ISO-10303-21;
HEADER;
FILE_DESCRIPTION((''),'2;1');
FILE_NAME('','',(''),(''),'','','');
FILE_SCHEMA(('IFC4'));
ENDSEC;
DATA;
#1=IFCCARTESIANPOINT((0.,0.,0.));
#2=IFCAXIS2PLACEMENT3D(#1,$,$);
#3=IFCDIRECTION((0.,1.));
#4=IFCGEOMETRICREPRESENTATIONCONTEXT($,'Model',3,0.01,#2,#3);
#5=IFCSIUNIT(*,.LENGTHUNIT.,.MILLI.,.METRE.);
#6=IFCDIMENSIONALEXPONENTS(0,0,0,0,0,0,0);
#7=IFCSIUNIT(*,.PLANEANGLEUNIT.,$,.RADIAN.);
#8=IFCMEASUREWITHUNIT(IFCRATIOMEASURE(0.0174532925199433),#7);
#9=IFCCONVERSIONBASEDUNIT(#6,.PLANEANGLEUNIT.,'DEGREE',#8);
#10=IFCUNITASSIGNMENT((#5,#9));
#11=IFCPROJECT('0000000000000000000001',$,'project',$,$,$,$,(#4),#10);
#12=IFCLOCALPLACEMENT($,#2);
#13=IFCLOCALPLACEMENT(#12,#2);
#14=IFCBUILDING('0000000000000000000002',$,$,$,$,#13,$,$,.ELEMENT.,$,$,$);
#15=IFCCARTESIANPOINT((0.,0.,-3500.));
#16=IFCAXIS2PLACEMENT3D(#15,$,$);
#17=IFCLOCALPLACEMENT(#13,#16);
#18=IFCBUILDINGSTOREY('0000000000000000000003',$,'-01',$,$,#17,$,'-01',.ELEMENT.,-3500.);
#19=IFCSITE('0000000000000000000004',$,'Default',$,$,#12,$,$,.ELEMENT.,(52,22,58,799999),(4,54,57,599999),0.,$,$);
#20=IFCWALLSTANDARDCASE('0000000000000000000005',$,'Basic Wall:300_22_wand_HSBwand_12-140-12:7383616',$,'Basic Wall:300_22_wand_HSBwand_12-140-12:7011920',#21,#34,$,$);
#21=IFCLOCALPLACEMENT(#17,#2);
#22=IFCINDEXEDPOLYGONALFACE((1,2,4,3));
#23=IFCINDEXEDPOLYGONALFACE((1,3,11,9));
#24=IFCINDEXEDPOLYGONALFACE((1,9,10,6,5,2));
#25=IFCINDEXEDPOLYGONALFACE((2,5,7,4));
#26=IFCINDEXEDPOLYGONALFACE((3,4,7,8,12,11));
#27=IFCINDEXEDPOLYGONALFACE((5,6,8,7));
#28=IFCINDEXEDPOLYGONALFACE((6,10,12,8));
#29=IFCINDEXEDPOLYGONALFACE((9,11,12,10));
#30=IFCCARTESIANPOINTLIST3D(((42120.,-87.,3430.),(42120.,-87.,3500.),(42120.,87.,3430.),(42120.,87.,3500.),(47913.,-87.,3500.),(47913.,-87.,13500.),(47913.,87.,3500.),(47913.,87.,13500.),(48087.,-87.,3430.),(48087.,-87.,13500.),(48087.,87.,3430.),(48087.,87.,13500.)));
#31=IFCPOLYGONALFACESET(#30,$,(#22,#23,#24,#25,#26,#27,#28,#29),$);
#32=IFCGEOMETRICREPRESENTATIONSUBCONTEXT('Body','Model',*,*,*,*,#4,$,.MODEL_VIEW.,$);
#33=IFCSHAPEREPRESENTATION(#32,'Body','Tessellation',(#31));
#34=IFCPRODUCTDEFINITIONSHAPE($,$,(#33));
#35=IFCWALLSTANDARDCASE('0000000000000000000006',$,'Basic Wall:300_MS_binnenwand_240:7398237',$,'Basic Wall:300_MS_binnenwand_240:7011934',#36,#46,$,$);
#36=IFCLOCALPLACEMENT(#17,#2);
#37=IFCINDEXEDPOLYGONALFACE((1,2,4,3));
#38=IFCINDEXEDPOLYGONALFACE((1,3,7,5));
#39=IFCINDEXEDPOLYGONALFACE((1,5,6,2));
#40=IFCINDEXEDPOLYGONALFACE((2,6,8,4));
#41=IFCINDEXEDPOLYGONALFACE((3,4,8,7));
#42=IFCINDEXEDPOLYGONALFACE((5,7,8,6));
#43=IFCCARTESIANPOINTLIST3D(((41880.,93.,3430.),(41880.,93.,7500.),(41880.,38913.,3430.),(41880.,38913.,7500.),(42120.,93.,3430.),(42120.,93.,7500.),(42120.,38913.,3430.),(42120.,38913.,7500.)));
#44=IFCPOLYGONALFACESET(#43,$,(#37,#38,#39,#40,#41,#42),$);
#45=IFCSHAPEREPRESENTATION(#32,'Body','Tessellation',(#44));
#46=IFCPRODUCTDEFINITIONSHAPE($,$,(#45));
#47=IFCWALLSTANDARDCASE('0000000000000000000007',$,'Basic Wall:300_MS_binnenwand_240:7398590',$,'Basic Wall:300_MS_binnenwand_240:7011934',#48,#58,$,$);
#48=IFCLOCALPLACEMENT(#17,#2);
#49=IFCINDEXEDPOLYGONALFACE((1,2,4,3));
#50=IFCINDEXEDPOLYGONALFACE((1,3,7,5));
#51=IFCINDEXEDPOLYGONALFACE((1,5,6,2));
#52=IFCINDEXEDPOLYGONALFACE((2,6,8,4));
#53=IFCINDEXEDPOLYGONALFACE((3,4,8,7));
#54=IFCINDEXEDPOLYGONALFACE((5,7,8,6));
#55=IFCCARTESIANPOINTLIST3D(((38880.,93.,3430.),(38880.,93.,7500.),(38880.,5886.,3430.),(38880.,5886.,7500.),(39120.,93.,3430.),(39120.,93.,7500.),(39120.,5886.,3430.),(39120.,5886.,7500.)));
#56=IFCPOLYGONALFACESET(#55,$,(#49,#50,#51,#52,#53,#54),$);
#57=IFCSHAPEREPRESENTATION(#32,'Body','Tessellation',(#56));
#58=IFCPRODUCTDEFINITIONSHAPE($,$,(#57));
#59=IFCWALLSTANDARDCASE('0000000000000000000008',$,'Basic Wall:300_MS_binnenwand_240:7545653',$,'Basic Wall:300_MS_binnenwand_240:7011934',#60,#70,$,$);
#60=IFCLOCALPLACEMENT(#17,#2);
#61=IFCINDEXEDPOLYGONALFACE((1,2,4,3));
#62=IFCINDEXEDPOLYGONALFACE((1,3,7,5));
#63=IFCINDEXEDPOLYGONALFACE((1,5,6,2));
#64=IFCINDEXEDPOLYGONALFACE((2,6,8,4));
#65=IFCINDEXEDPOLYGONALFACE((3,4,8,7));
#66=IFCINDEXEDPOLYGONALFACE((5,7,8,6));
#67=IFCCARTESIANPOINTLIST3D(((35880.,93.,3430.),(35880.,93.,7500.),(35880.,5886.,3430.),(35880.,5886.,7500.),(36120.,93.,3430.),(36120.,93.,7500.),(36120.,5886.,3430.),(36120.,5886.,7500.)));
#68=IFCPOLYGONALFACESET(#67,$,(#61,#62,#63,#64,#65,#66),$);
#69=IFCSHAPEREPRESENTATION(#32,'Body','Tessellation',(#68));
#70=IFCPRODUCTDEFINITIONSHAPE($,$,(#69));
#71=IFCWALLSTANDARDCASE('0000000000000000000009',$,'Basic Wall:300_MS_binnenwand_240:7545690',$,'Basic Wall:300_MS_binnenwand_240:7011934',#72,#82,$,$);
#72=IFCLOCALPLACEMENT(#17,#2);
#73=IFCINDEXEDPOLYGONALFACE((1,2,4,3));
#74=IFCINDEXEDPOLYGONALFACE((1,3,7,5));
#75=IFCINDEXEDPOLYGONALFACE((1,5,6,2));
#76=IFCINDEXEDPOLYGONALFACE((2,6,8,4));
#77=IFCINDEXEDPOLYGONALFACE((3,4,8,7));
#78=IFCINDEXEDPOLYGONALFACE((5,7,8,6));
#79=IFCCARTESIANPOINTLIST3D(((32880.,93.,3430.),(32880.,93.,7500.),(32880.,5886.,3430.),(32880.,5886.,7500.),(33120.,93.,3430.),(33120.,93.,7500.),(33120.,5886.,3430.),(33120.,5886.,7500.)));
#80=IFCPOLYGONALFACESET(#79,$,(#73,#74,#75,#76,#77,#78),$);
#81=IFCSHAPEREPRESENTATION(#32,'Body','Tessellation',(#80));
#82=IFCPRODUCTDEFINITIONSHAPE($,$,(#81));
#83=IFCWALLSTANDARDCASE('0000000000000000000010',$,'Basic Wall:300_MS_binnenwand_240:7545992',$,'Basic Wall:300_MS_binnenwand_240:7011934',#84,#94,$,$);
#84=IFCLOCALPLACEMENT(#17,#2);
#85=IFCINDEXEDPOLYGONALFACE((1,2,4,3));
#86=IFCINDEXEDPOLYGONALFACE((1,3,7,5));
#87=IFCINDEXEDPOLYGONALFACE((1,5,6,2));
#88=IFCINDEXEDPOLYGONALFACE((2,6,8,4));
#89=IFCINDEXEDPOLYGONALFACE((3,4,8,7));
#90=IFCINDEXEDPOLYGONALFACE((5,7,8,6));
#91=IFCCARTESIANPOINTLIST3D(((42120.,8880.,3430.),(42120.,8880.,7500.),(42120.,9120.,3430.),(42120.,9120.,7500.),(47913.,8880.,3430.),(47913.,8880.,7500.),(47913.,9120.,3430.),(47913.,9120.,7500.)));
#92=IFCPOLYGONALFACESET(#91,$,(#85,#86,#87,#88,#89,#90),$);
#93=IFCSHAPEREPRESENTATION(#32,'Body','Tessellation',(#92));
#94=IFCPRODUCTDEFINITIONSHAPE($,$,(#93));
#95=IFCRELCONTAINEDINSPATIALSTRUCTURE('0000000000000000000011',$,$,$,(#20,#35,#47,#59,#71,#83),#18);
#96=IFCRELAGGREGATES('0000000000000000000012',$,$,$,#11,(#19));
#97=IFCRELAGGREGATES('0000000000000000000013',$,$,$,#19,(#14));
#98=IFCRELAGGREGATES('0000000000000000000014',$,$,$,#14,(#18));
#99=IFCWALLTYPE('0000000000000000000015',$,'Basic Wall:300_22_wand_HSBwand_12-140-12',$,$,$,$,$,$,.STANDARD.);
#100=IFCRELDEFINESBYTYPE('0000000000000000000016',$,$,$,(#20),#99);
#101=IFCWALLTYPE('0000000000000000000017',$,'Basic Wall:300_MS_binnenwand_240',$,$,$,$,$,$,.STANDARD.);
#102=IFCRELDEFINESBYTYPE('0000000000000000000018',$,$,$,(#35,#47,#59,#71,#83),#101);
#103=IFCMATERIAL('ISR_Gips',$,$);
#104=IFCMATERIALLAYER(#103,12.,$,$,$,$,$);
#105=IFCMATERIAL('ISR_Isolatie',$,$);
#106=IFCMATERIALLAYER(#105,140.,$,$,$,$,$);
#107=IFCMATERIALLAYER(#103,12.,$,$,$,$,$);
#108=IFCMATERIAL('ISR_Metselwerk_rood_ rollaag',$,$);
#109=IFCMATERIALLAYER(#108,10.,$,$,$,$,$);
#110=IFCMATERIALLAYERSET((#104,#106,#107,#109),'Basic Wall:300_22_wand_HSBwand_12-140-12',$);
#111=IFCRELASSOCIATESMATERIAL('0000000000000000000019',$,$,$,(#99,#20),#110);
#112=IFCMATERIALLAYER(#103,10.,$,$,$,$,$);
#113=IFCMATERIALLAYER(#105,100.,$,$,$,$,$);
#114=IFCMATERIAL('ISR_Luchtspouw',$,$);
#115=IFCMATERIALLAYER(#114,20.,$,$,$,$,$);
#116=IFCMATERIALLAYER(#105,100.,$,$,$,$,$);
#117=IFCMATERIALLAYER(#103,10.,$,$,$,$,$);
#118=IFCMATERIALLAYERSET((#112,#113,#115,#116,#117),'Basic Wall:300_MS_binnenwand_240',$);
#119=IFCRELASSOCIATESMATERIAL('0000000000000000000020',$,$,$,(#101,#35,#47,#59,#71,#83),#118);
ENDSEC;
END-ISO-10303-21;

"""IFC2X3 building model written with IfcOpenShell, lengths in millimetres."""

from ifc_helpers import new_model, entity, si_unit, converted_unit, direction, frame, frame_2d, origin, place, context, subcontext, project, spatial, rectangle, extrude, material, layer, layer_set, layer_usage, type_object, element, save


model = new_model("IFC2X3")

# Units and contexts
model_context = context("Model", 3, precision=0.01, world=origin(), true_north=direction((0.0, 1.0)))
body_context = subcontext(model_context, "Body", "Model", "MODEL_VIEW")
ifc_project = project(units=[si_unit("LENGTHUNIT", "METRE", prefix="MILLI"), converted_unit("PLANEANGLEUNIT", "DEGREE", entity("IfcRatioMeasure", 0.0174532925199433), si_unit("PLANEANGLEUNIT", "RADIAN"), dimensions=[0, 0, 0, 0, 0, 0, 0])], contexts=[model_context])

# Site, building, storey
site_placement = place(None, origin())
site = spatial("IfcSite", under=ifc_project, at=site_placement, Name="Default", CompositionType="ELEMENT", RefLatitude=(52, 22, 58, 799999), RefLongitude=(4, 54, 57, 599999), RefElevation=0.0)
building_placement = place(site_placement, origin())
building = spatial("IfcBuilding", under=site, at=building_placement, CompositionType="ELEMENT")
storey_placement = place(building_placement, frame((0.0, 0.0, -3500.0)))
storey = spatial("IfcBuildingStorey", under=building, at=storey_placement, Name="-01", LongName="-01", CompositionType="ELEMENT", Elevation=-3500.0)

# Shared definitions
ifc_material_1 = material(Name="ISR_Gips")
ifc_layer_1 = layer(ifc_material_1, 12.0)
ifc_material_2 = material(Name="ISR_Isolatie")
ifc_layer_2 = layer(ifc_material_2, 140.0)
ifc_layer_3 = layer(ifc_material_1, 12.0)
ifc_material_3 = material(Name="ISR_Metselwerk_rood_ rollaag")
ifc_layer_4 = layer(ifc_material_3, 10.0)
ifc_layer_set_1 = layer_set([ifc_layer_1, ifc_layer_2, ifc_layer_3, ifc_layer_4], Name="Basic Wall:300_22_wand_HSBwand_12-140-12")
wall_type_1 = type_object("IfcWallType", Name="Basic Wall:300_22_wand_HSBwand_12-140-12", PredefinedType="STANDARD", material=ifc_layer_set_1)

# Wall, opening
ifc_layer_usage_1 = layer_usage(ifc_layer_set_1, "AXIS2", "NEGATIVE", 87.0)
wall_1_placement = place(storey_placement, frame((42120.0, 0.0, 3430.0)))
wall_1 = element("IfcWallStandardCase", 1, at=wall_1_placement, inside=storey, type_object=wall_type_1, material=ifc_layer_usage_1, Name="Basic Wall:300_22_wand_HSBwand_12-140-12:7383616", ObjectType="Basic Wall:300_22_wand_HSBwand_12-140-12:7011920", context=body_context, shape_type="SweptSolid", body=[
    extrude(rectangle(XDim=5967.0, YDim=174.0, at=frame_2d((2983.5, 0.0), x_axis=(-1.0, 0.0))), origin(), (0.0, 0.0, 1.0), 10070.0),
])
opening_1_placement = place(wall_1_placement, origin())
element("IfcOpeningElement", 2, at=opening_1_placement, cuts=wall_1, ObjectType="Opening", context=body_context, shape_type="SweptSolid", body=[
    extrude(rectangle(XDim=10000.0, YDim=5793.0, at=frame_2d((0.0, 0.0), x_axis=(0.0, 1.0))), frame((2896.5, -239.4, 5070.0), z_axis=(0.0, 1.0, 0.0), x_axis=(-1.0, 0.0, 0.0)), (0.0, 0.0, 1.0), 478.8),
])

# Walls
ifc_layer_5 = layer(ifc_material_1, 10.0)
ifc_layer_6 = layer(ifc_material_2, 100.0)
ifc_material_4 = material(Name="ISR_Luchtspouw")
ifc_layer_7 = layer(ifc_material_4, 20.0)
ifc_layer_8 = layer(ifc_material_2, 100.0)
ifc_layer_9 = layer(ifc_material_1, 10.0)
ifc_layer_set_2 = layer_set([ifc_layer_5, ifc_layer_6, ifc_layer_7, ifc_layer_8, ifc_layer_9], Name="Basic Wall:300_MS_binnenwand_240")
ifc_layer_usage_2 = layer_usage(ifc_layer_set_2, "AXIS2", "NEGATIVE", 120.0)
wall_type_2 = type_object("IfcWallType", Name="Basic Wall:300_MS_binnenwand_240", PredefinedType="STANDARD", material=ifc_layer_set_2)
wall_2_placement = place(storey_placement, frame((42000.0, 93.0, 3430.0), z_axis=(0.0, 0.0, 1.0), x_axis=(0.0, 1.0, 0.0)))
element("IfcWallStandardCase", 3, at=wall_2_placement, inside=storey, type_object=wall_type_2, material=ifc_layer_usage_2, Name="Basic Wall:300_MS_binnenwand_240:7398237", ObjectType="Basic Wall:300_MS_binnenwand_240:7011934", context=body_context, shape_type="SweptSolid", body=[
    extrude(rectangle(XDim=38820.0, YDim=240.0, at=frame_2d((19410.0, 0.0), x_axis=(-1.0, 0.0))), origin(), (0.0, 0.0, 1.0), 4070.0),
])
ifc_layer_usage_3 = layer_usage(ifc_layer_set_2, "AXIS2", "POSITIVE", -120.0)
wall_3_placement = place(storey_placement, frame((39000.0, 5886.0, 3430.0), z_axis=(0.0, 0.0, 1.0), x_axis=(0.0, -1.0, 0.0)))
element("IfcWallStandardCase", 4, at=wall_3_placement, inside=storey, type_object=wall_type_2, material=ifc_layer_usage_3, Name="Basic Wall:300_MS_binnenwand_240:7398590", ObjectType="Basic Wall:300_MS_binnenwand_240:7011934", context=body_context, shape_type="SweptSolid", body=[
    extrude(rectangle(XDim=5793.0, YDim=240.0, at=frame_2d((2896.5, 0.0), x_axis=(-1.0, 0.0))), origin(), (0.0, 0.0, 1.0), 4070.0),
])
ifc_layer_usage_4 = layer_usage(ifc_layer_set_2, "AXIS2", "POSITIVE", -120.0)
wall_4_placement = place(storey_placement, frame((36000.0, 5886.0, 3430.0), z_axis=(0.0, 0.0, 1.0), x_axis=(0.0, -1.0, 0.0)))
element("IfcWallStandardCase", 5, at=wall_4_placement, inside=storey, type_object=wall_type_2, material=ifc_layer_usage_4, Name="Basic Wall:300_MS_binnenwand_240:7545653", ObjectType="Basic Wall:300_MS_binnenwand_240:7011934", context=body_context, shape_type="SweptSolid", body=[
    extrude(rectangle(XDim=5793.0, YDim=240.0, at=frame_2d((2896.5, 0.0), x_axis=(-1.0, 0.0))), origin(), (0.0, 0.0, 1.0), 4070.0),
])
ifc_layer_usage_5 = layer_usage(ifc_layer_set_2, "AXIS2", "POSITIVE", -120.0)
wall_5_placement = place(storey_placement, frame((33000.0, 5886.0, 3430.0), z_axis=(0.0, 0.0, 1.0), x_axis=(0.0, -1.0, 0.0)))
element("IfcWallStandardCase", 6, at=wall_5_placement, inside=storey, type_object=wall_type_2, material=ifc_layer_usage_5, Name="Basic Wall:300_MS_binnenwand_240:7545690", ObjectType="Basic Wall:300_MS_binnenwand_240:7011934", context=body_context, shape_type="SweptSolid", body=[
    extrude(rectangle(XDim=5793.0, YDim=240.0, at=frame_2d((2896.5, 0.0), x_axis=(-1.0, 0.0))), origin(), (0.0, 0.0, 1.0), 4070.0),
])
ifc_layer_usage_6 = layer_usage(ifc_layer_set_2, "AXIS2", "POSITIVE", -120.0)
wall_6_placement = place(storey_placement, frame((47913.0, 9000.0, 3430.0), z_axis=(0.0, 0.0, 1.0), x_axis=(-1.0, 0.0, 0.0)))
element("IfcWallStandardCase", 7, at=wall_6_placement, inside=storey, type_object=wall_type_2, material=ifc_layer_usage_6, Name="Basic Wall:300_MS_binnenwand_240:7545992", ObjectType="Basic Wall:300_MS_binnenwand_240:7011934", context=body_context, shape_type="SweptSolid", body=[
    extrude(rectangle(XDim=5793.0, YDim=240.0, at=frame_2d((2896.5, 0.0), x_axis=(-1.0, 0.0))), origin(), (0.0, 0.0, 1.0), 4070.0),
])

save(model, "model.ifc")
